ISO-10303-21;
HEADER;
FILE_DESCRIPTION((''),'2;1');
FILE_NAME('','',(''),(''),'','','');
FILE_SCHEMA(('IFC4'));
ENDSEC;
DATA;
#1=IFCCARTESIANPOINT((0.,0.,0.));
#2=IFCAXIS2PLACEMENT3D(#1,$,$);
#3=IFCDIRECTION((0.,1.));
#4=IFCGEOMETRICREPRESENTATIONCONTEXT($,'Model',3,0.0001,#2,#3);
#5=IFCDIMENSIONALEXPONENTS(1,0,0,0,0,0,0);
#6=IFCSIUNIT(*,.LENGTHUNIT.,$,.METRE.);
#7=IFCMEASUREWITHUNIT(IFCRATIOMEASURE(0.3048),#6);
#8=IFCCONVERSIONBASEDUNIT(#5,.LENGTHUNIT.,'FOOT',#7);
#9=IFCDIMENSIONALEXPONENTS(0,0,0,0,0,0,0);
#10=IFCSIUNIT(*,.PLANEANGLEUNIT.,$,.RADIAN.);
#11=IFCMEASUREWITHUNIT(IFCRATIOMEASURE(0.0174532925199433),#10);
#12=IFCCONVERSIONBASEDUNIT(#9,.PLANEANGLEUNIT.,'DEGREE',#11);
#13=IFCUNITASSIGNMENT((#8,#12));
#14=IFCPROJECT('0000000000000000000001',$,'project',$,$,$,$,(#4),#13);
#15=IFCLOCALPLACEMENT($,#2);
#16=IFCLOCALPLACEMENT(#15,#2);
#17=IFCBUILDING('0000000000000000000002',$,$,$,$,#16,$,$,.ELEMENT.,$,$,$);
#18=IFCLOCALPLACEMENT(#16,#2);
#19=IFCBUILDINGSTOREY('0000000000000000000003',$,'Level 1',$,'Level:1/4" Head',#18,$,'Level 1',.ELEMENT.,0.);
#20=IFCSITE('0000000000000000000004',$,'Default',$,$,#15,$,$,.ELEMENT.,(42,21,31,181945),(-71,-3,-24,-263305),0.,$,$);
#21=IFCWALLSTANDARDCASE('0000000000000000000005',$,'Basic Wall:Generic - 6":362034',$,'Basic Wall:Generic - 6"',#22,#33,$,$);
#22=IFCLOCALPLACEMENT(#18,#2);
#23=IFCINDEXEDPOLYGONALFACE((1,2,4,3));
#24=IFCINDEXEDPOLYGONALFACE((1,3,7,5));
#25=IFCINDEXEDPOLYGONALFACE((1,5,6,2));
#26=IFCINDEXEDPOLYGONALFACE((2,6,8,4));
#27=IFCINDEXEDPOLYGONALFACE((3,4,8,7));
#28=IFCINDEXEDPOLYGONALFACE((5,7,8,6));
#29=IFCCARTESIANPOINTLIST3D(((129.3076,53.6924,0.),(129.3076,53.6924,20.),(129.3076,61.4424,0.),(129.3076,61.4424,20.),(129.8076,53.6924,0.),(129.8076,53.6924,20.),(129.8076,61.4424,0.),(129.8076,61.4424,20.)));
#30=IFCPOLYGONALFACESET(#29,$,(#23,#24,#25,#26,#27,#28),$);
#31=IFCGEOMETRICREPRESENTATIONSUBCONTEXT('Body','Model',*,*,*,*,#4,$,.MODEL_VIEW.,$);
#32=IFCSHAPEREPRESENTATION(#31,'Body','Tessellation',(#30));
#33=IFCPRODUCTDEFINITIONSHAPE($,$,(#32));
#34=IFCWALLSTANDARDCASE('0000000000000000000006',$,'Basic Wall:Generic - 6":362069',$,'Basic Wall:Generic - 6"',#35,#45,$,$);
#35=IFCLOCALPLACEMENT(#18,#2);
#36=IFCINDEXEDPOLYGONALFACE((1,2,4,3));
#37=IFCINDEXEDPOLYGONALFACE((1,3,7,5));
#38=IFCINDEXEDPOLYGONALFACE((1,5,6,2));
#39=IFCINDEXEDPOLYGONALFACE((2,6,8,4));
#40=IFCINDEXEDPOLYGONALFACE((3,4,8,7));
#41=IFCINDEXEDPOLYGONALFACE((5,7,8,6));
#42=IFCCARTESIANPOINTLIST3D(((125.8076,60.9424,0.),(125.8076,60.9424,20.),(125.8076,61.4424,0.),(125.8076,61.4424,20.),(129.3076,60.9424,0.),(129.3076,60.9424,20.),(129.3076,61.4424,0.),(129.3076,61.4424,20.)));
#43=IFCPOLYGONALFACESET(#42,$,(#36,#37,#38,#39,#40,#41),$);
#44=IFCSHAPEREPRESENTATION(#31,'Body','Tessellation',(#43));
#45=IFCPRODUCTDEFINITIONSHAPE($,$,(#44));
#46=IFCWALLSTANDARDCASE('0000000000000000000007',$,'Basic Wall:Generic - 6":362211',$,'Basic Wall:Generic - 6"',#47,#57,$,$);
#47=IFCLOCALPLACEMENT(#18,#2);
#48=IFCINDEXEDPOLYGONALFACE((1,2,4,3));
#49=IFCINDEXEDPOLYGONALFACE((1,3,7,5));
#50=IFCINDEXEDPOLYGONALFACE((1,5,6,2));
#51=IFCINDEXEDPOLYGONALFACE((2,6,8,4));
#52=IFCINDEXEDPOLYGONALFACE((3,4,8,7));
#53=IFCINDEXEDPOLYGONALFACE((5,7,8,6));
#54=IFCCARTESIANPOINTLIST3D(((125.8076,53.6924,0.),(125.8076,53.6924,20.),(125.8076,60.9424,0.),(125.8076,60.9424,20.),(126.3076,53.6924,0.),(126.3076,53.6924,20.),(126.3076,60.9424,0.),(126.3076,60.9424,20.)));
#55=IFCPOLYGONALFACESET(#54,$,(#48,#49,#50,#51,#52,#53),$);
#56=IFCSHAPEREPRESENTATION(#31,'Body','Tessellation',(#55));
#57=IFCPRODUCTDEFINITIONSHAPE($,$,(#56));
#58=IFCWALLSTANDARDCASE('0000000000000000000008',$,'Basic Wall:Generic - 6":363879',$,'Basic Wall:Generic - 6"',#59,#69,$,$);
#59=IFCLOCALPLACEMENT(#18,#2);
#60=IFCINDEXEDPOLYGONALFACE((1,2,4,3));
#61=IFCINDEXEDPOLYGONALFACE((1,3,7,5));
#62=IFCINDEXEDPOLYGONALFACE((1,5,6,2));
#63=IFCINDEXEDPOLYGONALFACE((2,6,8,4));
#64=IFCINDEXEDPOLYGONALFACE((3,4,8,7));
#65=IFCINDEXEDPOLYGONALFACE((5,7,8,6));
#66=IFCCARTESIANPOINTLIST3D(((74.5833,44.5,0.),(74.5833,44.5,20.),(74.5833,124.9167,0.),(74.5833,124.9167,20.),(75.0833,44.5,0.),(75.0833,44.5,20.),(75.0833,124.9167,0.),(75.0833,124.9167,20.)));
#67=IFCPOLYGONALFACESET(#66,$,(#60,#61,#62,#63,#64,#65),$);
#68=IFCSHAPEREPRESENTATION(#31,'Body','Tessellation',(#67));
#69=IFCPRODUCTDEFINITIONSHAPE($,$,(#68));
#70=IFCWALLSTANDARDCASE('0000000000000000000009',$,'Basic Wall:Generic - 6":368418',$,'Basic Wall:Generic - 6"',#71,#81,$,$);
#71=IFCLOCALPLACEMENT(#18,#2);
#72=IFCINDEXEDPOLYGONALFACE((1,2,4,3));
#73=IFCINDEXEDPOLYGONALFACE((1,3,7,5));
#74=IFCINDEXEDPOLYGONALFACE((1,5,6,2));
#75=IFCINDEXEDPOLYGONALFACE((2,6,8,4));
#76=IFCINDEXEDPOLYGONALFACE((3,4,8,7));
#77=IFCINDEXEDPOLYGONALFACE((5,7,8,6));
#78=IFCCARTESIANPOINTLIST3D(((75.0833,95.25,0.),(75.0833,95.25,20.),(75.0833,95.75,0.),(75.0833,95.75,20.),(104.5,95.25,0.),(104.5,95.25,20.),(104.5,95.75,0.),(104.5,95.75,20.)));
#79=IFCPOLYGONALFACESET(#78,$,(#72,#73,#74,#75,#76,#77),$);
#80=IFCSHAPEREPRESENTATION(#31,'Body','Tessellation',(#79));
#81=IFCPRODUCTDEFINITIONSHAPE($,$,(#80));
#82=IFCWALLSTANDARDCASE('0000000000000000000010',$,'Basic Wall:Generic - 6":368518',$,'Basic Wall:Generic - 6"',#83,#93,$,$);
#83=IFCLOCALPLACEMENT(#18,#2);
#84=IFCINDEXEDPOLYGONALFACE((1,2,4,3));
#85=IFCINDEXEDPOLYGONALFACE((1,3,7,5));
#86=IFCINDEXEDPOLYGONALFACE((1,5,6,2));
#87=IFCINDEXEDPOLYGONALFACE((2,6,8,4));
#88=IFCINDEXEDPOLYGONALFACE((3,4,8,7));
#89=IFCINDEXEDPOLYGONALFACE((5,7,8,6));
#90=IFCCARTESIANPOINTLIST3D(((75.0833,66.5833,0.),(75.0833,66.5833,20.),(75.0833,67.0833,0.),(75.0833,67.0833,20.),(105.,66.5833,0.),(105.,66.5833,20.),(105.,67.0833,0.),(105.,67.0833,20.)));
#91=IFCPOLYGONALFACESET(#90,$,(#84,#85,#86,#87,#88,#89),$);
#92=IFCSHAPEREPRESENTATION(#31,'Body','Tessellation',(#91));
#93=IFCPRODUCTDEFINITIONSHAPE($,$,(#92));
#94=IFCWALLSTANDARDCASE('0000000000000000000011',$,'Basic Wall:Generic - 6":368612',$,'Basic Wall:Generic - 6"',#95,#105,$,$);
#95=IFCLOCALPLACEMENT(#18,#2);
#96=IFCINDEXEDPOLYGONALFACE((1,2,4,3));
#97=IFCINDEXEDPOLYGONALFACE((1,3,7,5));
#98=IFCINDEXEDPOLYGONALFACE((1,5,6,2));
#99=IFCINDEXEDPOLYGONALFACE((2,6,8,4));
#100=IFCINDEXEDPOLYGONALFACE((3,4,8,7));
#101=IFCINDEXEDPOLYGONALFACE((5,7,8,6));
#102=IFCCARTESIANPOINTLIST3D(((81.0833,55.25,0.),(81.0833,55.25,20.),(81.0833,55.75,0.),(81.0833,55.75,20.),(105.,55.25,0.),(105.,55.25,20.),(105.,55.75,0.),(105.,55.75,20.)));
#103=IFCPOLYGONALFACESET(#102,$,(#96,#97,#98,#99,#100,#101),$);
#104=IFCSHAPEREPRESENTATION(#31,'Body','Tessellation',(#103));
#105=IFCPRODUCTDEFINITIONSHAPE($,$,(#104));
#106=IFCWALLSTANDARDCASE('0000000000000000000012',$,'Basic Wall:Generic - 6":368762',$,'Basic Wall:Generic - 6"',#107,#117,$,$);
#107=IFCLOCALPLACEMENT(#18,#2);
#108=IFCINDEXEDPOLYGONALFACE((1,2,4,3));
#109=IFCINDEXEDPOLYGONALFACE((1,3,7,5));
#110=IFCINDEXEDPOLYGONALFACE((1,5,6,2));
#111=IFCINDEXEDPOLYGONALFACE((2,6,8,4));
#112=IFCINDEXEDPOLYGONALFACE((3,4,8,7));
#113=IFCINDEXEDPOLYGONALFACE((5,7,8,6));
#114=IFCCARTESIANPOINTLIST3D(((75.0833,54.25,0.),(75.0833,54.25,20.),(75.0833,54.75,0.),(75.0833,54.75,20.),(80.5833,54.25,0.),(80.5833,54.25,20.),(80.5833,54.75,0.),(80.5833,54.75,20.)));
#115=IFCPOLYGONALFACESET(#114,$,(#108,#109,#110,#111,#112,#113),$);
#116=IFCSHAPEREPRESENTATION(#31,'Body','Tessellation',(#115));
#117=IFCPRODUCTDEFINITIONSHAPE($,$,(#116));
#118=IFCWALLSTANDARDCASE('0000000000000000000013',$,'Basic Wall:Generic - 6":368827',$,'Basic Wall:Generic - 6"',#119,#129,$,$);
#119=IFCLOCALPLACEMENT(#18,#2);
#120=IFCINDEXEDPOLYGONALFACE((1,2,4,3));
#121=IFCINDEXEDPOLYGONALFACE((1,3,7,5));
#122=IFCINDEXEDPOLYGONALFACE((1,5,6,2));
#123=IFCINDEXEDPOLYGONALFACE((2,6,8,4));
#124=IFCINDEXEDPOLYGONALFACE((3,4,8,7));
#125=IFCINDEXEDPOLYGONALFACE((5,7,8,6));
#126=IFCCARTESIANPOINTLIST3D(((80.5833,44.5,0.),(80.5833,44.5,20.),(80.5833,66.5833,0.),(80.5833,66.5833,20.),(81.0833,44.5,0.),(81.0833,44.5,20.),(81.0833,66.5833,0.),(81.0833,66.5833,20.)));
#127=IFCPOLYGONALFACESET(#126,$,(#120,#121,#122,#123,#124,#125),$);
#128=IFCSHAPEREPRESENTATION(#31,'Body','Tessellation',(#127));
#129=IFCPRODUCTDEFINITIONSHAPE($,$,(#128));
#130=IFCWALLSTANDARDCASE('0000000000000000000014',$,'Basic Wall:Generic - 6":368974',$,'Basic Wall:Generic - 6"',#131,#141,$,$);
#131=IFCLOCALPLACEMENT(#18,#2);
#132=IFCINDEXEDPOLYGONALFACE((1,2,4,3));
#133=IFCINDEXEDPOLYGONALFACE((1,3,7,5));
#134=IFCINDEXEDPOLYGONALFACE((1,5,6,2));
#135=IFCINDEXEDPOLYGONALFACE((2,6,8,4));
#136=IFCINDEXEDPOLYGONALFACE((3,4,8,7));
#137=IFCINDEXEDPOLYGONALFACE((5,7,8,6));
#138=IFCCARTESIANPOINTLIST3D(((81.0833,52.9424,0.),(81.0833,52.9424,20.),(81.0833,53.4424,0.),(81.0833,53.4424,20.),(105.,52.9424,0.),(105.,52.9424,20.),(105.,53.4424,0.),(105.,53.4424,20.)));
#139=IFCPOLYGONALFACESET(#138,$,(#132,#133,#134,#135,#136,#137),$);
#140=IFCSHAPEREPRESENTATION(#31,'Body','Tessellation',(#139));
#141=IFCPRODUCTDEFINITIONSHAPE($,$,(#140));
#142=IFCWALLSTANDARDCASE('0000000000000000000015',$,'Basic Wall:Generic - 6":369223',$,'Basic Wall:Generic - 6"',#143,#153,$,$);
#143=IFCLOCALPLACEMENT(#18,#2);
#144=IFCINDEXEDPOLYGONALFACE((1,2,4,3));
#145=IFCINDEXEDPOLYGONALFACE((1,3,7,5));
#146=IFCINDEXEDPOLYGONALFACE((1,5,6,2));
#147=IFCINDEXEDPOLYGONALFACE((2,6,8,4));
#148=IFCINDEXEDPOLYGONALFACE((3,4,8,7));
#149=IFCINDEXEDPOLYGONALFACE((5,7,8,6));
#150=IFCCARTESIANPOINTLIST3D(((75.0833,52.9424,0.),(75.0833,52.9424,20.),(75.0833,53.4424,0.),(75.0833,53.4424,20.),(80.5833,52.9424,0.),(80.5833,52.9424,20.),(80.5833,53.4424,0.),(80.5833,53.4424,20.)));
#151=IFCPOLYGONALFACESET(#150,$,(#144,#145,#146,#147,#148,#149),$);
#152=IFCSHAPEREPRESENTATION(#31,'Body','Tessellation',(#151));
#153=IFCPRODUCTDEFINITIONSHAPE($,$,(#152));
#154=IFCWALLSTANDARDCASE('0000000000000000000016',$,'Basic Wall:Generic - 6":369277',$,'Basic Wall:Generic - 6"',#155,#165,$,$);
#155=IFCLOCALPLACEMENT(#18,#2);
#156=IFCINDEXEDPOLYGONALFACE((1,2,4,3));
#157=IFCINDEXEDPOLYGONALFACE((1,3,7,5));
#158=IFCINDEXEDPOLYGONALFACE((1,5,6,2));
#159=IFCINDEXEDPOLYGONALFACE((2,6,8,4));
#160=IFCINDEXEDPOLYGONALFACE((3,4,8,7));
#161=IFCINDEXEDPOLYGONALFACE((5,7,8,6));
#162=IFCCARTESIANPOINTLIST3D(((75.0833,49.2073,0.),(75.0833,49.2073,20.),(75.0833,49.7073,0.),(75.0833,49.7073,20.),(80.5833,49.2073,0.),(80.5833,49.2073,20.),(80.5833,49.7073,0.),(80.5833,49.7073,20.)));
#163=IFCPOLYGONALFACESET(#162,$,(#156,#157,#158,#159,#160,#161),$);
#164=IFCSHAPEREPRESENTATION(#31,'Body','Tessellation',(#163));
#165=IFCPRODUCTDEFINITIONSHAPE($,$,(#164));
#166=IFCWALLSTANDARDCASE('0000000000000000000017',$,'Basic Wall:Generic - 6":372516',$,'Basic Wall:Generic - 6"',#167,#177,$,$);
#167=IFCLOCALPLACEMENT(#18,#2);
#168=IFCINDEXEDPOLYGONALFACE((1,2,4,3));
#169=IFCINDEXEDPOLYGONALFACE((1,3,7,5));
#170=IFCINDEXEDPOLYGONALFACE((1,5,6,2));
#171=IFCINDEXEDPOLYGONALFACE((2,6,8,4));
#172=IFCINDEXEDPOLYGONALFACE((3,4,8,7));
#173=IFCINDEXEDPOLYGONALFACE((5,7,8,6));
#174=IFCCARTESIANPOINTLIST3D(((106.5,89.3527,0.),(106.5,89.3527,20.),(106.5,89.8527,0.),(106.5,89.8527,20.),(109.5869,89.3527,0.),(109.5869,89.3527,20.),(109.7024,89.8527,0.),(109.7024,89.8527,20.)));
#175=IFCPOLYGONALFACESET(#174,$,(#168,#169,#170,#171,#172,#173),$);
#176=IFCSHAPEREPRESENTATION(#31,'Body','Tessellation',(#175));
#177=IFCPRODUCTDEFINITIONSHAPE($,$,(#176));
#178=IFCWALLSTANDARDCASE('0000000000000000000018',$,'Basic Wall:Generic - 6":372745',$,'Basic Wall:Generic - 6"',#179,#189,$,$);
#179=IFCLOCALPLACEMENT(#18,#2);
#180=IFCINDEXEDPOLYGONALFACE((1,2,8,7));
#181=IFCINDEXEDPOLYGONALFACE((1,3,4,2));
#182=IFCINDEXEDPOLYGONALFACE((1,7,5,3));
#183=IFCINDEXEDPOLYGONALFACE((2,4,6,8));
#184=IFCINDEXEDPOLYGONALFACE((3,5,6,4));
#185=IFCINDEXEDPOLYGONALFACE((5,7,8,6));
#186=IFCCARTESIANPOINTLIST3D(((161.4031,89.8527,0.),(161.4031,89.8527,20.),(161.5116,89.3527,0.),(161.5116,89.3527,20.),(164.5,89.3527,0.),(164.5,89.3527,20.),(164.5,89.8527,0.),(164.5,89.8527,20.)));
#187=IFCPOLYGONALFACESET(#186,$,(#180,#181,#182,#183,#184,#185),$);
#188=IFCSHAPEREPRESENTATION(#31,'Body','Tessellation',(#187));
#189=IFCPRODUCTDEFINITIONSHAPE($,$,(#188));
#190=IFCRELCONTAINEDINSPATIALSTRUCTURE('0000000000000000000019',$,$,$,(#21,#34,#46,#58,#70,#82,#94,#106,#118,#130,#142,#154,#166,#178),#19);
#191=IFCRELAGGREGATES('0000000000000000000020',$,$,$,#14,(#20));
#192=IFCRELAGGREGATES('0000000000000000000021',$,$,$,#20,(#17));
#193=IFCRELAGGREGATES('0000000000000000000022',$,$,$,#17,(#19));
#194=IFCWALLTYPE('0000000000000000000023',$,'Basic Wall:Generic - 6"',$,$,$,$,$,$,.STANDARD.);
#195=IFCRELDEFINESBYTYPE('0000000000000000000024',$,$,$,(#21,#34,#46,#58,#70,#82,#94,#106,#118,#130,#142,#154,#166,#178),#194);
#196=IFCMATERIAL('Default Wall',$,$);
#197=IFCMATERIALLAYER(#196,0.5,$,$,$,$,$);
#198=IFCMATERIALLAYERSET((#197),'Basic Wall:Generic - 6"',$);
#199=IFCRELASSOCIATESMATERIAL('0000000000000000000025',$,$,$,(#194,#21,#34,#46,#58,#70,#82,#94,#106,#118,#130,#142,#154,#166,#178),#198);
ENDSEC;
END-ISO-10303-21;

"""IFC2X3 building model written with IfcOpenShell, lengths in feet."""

from ifc_helpers import new_model, entity, si_unit, converted_unit, direction, frame, frame_2d, origin, place, context, subcontext, project, spatial, polyline, rectangle, outline, extrude, material, layer, layer_set, layer_usage, type_object, element, save


model = new_model("IFC2X3")

# Units and contexts
model_context = context("Model", 3, precision=0.0001, world=origin(), true_north=direction((0.0, 1.0)))
body_context = subcontext(model_context, "Body", "Model", "MODEL_VIEW")
ifc_project = project(units=[converted_unit("LENGTHUNIT", "FOOT", entity("IfcRatioMeasure", 0.3048), si_unit("LENGTHUNIT", "METRE"), dimensions=[1, 0, 0, 0, 0, 0, 0]), converted_unit("PLANEANGLEUNIT", "DEGREE", entity("IfcRatioMeasure", 0.0174532925199433), si_unit("PLANEANGLEUNIT", "RADIAN"), dimensions=[0, 0, 0, 0, 0, 0, 0])], contexts=[model_context])

# Site, building, storey
site_placement = place(None, origin())
site = spatial("IfcSite", under=ifc_project, at=site_placement, Name="Default", CompositionType="ELEMENT", RefLatitude=(42, 21, 31, 181945), RefLongitude=(-71, -3, -24, -263305), RefElevation=0.0)
building_placement = place(site_placement, origin())
building = spatial("IfcBuilding", under=site, at=building_placement, CompositionType="ELEMENT")
storey_placement = place(building_placement, origin())
storey = spatial("IfcBuildingStorey", under=building, at=storey_placement, Name="Level 1", ObjectType="Level:1/4\" Head", LongName="Level 1", CompositionType="ELEMENT", Elevation=0.0)

# Walls
ifc_material = material(Name="Default Wall")
ifc_layer_1 = layer(ifc_material, 0.5)
ifc_layer_set_1 = layer_set([ifc_layer_1], Name="Basic Wall:Generic - 6\"")
wall_type_1 = type_object("IfcWallType", Name="Basic Wall:Generic - 6\"", PredefinedType="STANDARD", material=ifc_layer_set_1)
ifc_layer_usage_1 = layer_usage(ifc_layer_set_1, "AXIS2", "NEGATIVE", 0.25)
wall_1_placement = place(storey_placement, frame((129.5576, 53.6924, 0.0), z_axis=(0.0, 0.0, 1.0), x_axis=(0.0, 1.0, 0.0)))
element("IfcWallStandardCase", 1, at=wall_1_placement, inside=storey, type_object=wall_type_1, material=ifc_layer_usage_1, Name="Basic Wall:Generic - 6\":362034", ObjectType="Basic Wall:Generic - 6\"", context=body_context, shape_type="SweptSolid", body=[
    extrude(rectangle(XDim=7.75, YDim=0.5, at=frame_2d((3.875, 0.0), x_axis=(-1.0, 0.0))), origin(), (0.0, 0.0, 1.0), 20.0),
])
ifc_layer_usage_2 = layer_usage(ifc_layer_set_1, "AXIS2", "NEGATIVE", 0.25)
wall_2_placement = place(storey_placement, frame((129.3076, 61.1924, 0.0), z_axis=(0.0, 0.0, 1.0), x_axis=(-1.0, 0.0, 0.0)))
element("IfcWallStandardCase", 2, at=wall_2_placement, inside=storey, type_object=wall_type_1, material=ifc_layer_usage_2, Name="Basic Wall:Generic - 6\":362069", ObjectType="Basic Wall:Generic - 6\"", context=body_context, shape_type="SweptSolid", body=[
    extrude(rectangle(XDim=3.5, YDim=0.5, at=frame_2d((1.75, 0.0), x_axis=(-1.0, 0.0))), origin(), (0.0, 0.0, 1.0), 20.0),
])
ifc_layer_usage_3 = layer_usage(ifc_layer_set_1, "AXIS2", "NEGATIVE", 0.25)
wall_3_placement = place(storey_placement, frame((126.0576, 60.9424, 0.0), z_axis=(0.0, 0.0, 1.0), x_axis=(0.0, -1.0, 0.0)))
element("IfcWallStandardCase", 3, at=wall_3_placement, inside=storey, type_object=wall_type_1, material=ifc_layer_usage_3, Name="Basic Wall:Generic - 6\":362211", ObjectType="Basic Wall:Generic - 6\"", context=body_context, shape_type="SweptSolid", body=[
    extrude(rectangle(XDim=7.25, YDim=0.5, at=frame_2d((3.625, 0.0), x_axis=(-1.0, 0.0))), origin(), (0.0, 0.0, 1.0), 20.0),
])
ifc_layer_usage_4 = layer_usage(ifc_layer_set_1, "AXIS2", "NEGATIVE", 0.25)
wall_4_placement = place(storey_placement, frame((74.8333, 44.5, 0.0), z_axis=(0.0, 0.0, 1.0), x_axis=(0.0, 1.0, 0.0)))
element("IfcWallStandardCase", 4, at=wall_4_placement, inside=storey, type_object=wall_type_1, material=ifc_layer_usage_4, Name="Basic Wall:Generic - 6\":363879", ObjectType="Basic Wall:Generic - 6\"", context=body_context, shape_type="SweptSolid", body=[
    extrude(rectangle(XDim=80.4167, YDim=0.5, at=frame_2d((40.2083, 0.0), x_axis=(-1.0, 0.0))), origin(), (0.0, 0.0, 1.0), 20.0),
])
ifc_layer_usage_5 = layer_usage(ifc_layer_set_1, "AXIS2", "NEGATIVE", 0.25)
wall_5_placement = place(storey_placement, frame((75.0833, 95.5, 0.0)))
element("IfcWallStandardCase", 5, at=wall_5_placement, inside=storey, type_object=wall_type_1, material=ifc_layer_usage_5, Name="Basic Wall:Generic - 6\":368418", ObjectType="Basic Wall:Generic - 6\"", context=body_context, shape_type="SweptSolid", body=[
    extrude(rectangle(XDim=29.4167, YDim=0.5, at=frame_2d((14.7083, 0.0), x_axis=(-1.0, 0.0))), origin(), (0.0, 0.0, 1.0), 20.0),
])
ifc_layer_usage_6 = layer_usage(ifc_layer_set_1, "AXIS2", "NEGATIVE", 0.25)
wall_6_placement = place(storey_placement, frame((75.0833, 66.8333, 0.0)))
element("IfcWallStandardCase", 6, at=wall_6_placement, inside=storey, type_object=wall_type_1, material=ifc_layer_usage_6, Name="Basic Wall:Generic - 6\":368518", ObjectType="Basic Wall:Generic - 6\"", context=body_context, shape_type="SweptSolid", body=[
    extrude(rectangle(XDim=29.9167, YDim=0.5, at=frame_2d((14.9583, 0.0), x_axis=(-1.0, 0.0))), origin(), (0.0, 0.0, 1.0), 20.0),
])
ifc_layer_usage_7 = layer_usage(ifc_layer_set_1, "AXIS2", "NEGATIVE", 0.25)
wall_7_placement = place(storey_placement, frame((81.0833, 55.5, 0.0)))
element("IfcWallStandardCase", 7, at=wall_7_placement, inside=storey, type_object=wall_type_1, material=ifc_layer_usage_7, Name="Basic Wall:Generic - 6\":368612", ObjectType="Basic Wall:Generic - 6\"", context=body_context, shape_type="SweptSolid", body=[
    extrude(rectangle(XDim=23.9167, YDim=0.5, at=frame_2d((11.9583, 0.0), x_axis=(-1.0, 0.0))), origin(), (0.0, 0.0, 1.0), 20.0),
])
ifc_layer_usage_8 = layer_usage(ifc_layer_set_1, "AXIS2", "NEGATIVE", 0.25)
wall_8_placement = place(storey_placement, frame((75.0833, 54.5, 0.0)))
element("IfcWallStandardCase", 8, at=wall_8_placement, inside=storey, type_object=wall_type_1, material=ifc_layer_usage_8, Name="Basic Wall:Generic - 6\":368762", ObjectType="Basic Wall:Generic - 6\"", context=body_context, shape_type="SweptSolid", body=[
    extrude(rectangle(XDim=5.5, YDim=0.5, at=frame_2d((2.75, 0.0), x_axis=(-1.0, 0.0))), origin(), (0.0, 0.0, 1.0), 20.0),
])
ifc_layer_usage_9 = layer_usage(ifc_layer_set_1, "AXIS2", "NEGATIVE", 0.25)
wall_9_placement = place(storey_placement, frame((80.8333, 44.5, 0.0), z_axis=(0.0, 0.0, 1.0), x_axis=(0.0, 1.0, 0.0)))
element("IfcWallStandardCase", 9, at=wall_9_placement, inside=storey, type_object=wall_type_1, material=ifc_layer_usage_9, Name="Basic Wall:Generic - 6\":368827", ObjectType="Basic Wall:Generic - 6\"", context=body_context, shape_type="SweptSolid", body=[
    extrude(rectangle(XDim=22.0833, YDim=0.5, at=frame_2d((11.0417, 0.0), x_axis=(-1.0, 0.0))), origin(), (0.0, 0.0, 1.0), 20.0),
])
ifc_layer_usage_10 = layer_usage(ifc_layer_set_1, "AXIS2", "NEGATIVE", 0.25)
wall_10_placement = place(storey_placement, frame((105.0, 53.1924, 0.0), z_axis=(0.0, 0.0, 1.0), x_axis=(-1.0, 0.0, 0.0)))
element("IfcWallStandardCase", 10, at=wall_10_placement, inside=storey, type_object=wall_type_1, material=ifc_layer_usage_10, Name="Basic Wall:Generic - 6\":368974", ObjectType="Basic Wall:Generic - 6\"", context=body_context, shape_type="SweptSolid", body=[
    extrude(rectangle(XDim=23.9167, YDim=0.5, at=frame_2d((11.9583, 0.0), x_axis=(-1.0, 0.0))), origin(), (0.0, 0.0, 1.0), 20.0),
])
ifc_layer_usage_11 = layer_usage(ifc_layer_set_1, "AXIS2", "NEGATIVE", 0.25)
wall_11_placement = place(storey_placement, frame((75.0833, 53.1924, 0.0)))
element("IfcWallStandardCase", 11, at=wall_11_placement, inside=storey, type_object=wall_type_1, material=ifc_layer_usage_11, Name="Basic Wall:Generic - 6\":369223", ObjectType="Basic Wall:Generic - 6\"", context=body_context, shape_type="SweptSolid", body=[
    extrude(rectangle(XDim=5.5, YDim=0.5, at=frame_2d((2.75, 0.0), x_axis=(-1.0, 0.0))), origin(), (0.0, 0.0, 1.0), 20.0),
])
ifc_layer_usage_12 = layer_usage(ifc_layer_set_1, "AXIS2", "NEGATIVE", 0.25)
wall_12_placement = place(storey_placement, frame((75.0833, 49.4573, 0.0)))
element("IfcWallStandardCase", 12, at=wall_12_placement, inside=storey, type_object=wall_type_1, material=ifc_layer_usage_12, Name="Basic Wall:Generic - 6\":369277", ObjectType="Basic Wall:Generic - 6\"", context=body_context, shape_type="SweptSolid", body=[
    extrude(rectangle(XDim=5.5, YDim=0.5, at=frame_2d((2.75, 0.0), x_axis=(-1.0, 0.0))), origin(), (0.0, 0.0, 1.0), 20.0),
])
ifc_layer_usage_13 = layer_usage(ifc_layer_set_1, "AXIS2", "NEGATIVE", 0.25)
wall_13_placement = place(storey_placement, frame((109.7024, 89.6027, 0.0), z_axis=(0.0, 0.0, 1.0), x_axis=(-1.0, 0.0, 0.0)))
element("IfcWallStandardCase", 13, at=wall_13_placement, inside=storey, type_object=wall_type_1, material=ifc_layer_usage_13, Name="Basic Wall:Generic - 6\":372516", ObjectType="Basic Wall:Generic - 6\"", context=body_context, shape_type="SweptSolid", body=[
    extrude(outline(polyline([(3.2024, -0.25), (3.2024, 0.25), (0.1154, 0.25), (0.0, -0.25), (3.2024, -0.25)])), origin(), (0.0, 0.0, 1.0), 20.0),
])
ifc_layer_usage_14 = layer_usage(ifc_layer_set_1, "AXIS2", "NEGATIVE", 0.25)
wall_14_placement = place(storey_placement, frame((164.5, 89.6027, 0.0), z_axis=(0.0, 0.0, 1.0), x_axis=(-1.0, 0.0, 0.0)))
element("IfcWallStandardCase", 14, at=wall_14_placement, inside=storey, type_object=wall_type_1, material=ifc_layer_usage_14, Name="Basic Wall:Generic - 6\":372745", ObjectType="Basic Wall:Generic - 6\"", context=body_context, shape_type="SweptSolid", body=[
    extrude(outline(polyline([(3.0969, -0.25), (2.9884, 0.25), (0.0, 0.25), (0.0, -0.25), (3.0969, -0.25)])), origin(), (0.0, 0.0, 1.0), 20.0),
])

save(model, "model.ifc")
